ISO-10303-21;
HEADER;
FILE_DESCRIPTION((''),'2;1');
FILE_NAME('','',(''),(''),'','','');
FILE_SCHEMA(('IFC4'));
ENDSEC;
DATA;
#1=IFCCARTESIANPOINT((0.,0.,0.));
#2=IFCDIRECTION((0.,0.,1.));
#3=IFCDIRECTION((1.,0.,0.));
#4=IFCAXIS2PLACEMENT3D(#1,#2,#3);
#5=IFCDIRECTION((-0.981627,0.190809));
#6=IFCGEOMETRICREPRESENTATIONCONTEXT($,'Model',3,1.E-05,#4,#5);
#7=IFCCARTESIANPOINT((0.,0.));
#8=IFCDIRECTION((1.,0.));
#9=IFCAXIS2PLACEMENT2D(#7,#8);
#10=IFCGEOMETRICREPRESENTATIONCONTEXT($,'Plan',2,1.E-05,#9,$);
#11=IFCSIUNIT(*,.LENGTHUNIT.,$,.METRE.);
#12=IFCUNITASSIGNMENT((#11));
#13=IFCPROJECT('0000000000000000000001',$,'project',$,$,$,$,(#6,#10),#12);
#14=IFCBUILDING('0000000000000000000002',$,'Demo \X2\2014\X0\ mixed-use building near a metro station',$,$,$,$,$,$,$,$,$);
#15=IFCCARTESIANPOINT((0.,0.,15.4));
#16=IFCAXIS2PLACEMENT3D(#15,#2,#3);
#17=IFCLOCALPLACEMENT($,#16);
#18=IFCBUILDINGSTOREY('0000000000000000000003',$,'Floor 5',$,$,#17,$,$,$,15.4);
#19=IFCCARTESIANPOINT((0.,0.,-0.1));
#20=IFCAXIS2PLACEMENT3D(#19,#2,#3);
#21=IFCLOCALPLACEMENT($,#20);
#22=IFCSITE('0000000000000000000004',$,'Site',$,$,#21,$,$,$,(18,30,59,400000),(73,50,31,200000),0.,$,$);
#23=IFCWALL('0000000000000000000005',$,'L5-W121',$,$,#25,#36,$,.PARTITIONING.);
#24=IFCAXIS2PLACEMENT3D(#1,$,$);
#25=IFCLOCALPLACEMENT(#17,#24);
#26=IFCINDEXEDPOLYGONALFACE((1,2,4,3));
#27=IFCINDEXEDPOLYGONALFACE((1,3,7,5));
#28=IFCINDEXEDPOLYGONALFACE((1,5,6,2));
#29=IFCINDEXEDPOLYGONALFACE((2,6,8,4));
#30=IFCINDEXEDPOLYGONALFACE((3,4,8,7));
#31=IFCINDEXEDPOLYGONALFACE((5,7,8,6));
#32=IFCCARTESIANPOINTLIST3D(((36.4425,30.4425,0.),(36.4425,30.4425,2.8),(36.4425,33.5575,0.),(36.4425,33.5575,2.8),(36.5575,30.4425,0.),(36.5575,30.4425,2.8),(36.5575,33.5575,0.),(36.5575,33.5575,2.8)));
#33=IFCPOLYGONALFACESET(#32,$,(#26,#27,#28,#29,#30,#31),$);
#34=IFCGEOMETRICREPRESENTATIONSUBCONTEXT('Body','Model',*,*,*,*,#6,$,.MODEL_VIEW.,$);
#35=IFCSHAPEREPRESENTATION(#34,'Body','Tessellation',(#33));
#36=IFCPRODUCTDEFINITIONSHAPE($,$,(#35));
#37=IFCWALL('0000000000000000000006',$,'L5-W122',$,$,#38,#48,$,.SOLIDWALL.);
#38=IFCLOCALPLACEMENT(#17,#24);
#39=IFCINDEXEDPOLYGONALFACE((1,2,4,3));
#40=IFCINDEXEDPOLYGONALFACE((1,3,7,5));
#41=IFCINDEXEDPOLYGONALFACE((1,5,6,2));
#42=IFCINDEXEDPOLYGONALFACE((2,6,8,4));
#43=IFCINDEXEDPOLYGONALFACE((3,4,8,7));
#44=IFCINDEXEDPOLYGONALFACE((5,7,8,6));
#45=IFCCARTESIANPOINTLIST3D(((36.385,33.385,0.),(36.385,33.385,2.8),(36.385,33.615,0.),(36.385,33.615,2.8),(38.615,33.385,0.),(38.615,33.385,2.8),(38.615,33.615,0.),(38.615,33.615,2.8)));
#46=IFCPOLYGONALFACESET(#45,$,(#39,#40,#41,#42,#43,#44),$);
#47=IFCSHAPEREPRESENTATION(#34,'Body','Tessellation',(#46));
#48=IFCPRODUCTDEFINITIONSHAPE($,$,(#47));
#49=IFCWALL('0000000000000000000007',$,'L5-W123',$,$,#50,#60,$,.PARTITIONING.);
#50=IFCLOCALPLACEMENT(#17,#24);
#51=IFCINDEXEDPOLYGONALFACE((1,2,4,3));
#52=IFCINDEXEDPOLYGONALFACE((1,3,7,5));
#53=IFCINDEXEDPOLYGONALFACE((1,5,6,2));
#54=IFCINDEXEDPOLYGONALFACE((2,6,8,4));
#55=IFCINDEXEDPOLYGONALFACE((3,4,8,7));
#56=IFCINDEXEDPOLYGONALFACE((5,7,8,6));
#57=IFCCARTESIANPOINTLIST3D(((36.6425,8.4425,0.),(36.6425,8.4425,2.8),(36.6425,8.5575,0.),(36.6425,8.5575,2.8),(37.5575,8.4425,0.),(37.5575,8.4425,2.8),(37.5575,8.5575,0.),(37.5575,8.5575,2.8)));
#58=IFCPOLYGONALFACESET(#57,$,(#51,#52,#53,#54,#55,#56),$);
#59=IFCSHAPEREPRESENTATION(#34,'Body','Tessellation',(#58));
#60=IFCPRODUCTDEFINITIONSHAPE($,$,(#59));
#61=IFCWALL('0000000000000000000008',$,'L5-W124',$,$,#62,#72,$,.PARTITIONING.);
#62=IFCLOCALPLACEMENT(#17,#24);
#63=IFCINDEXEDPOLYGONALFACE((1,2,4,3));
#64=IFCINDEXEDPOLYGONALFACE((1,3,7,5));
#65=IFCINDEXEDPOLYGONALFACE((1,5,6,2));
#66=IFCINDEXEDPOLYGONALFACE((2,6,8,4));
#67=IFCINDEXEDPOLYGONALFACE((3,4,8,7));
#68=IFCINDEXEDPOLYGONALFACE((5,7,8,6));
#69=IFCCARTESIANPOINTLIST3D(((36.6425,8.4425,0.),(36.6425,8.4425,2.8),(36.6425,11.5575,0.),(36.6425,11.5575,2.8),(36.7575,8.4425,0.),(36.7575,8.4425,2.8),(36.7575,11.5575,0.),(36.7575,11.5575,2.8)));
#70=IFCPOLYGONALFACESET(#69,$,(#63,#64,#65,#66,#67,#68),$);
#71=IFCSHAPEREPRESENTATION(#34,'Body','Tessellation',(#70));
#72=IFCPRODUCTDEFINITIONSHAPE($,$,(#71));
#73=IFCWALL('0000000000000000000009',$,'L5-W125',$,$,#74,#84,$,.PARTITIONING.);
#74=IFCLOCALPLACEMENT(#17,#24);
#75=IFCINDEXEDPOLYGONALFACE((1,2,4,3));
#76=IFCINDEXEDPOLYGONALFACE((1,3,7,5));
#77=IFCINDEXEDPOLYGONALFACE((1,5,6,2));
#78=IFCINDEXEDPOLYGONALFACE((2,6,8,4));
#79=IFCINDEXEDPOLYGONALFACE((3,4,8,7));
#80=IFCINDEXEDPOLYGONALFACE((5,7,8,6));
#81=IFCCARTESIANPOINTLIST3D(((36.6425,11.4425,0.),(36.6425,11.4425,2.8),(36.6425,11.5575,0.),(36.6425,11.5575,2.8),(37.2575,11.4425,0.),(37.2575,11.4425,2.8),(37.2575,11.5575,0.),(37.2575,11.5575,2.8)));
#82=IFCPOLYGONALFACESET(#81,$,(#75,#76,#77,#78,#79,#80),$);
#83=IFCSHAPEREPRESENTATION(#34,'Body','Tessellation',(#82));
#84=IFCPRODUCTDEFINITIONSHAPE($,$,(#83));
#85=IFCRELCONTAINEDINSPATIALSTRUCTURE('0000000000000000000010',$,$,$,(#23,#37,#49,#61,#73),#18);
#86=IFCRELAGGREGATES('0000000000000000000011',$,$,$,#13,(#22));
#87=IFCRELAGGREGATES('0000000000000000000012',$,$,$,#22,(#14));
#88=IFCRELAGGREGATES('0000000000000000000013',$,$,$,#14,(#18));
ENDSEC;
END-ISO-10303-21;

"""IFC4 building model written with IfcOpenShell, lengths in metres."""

from ifc_helpers import new_model, si_unit, direction, frame, origin_with_axes, origin_2d_with_axis, place, context, subcontext, project, spatial, line, indexed_curve, outline, extrude, element, save


model = new_model("IFC4")

# Units and contexts
model_context = context("Model", 3, precision=1e-05, world=origin_with_axes(), true_north=direction((-0.981627, 0.190809)))
plan_context = context("Plan", 2, precision=1e-05, world=origin_2d_with_axis())
body_context = subcontext(model_context, "Body", "Model", "MODEL_VIEW")
ifc_project = project(units=[si_unit("LENGTHUNIT", "METRE")], contexts=[model_context, plan_context])

# Site, building, storey
site_placement = place(None, frame((0.0, 0.0, -0.1), z_axis=(0.0, 0.0, 1.0), x_axis=(1.0, 0.0, 0.0)))
site = spatial("IfcSite", under=ifc_project, at=site_placement, Name="Site", RefLatitude=(18, 30, 59, 400000), RefLongitude=(73, 50, 31, 200000), RefElevation=0.0)
building = spatial("IfcBuilding", under=site, Name="Demo — mixed-use building near a metro station")
storey_placement = place(None, frame((0.0, 0.0, 15.4), z_axis=(0.0, 0.0, 1.0), x_axis=(1.0, 0.0, 0.0)))
storey = spatial("IfcBuildingStorey", under=building, at=storey_placement, Name="Floor 5", Elevation=15.4)

# Walls
wall_1_placement = place(storey_placement, frame((0.0, 0.0, -15.4), z_axis=(0.0, 0.0, 1.0), x_axis=(1.0, 0.0, 0.0)))
element("IfcWall", 1, at=wall_1_placement, inside=storey, Name="L5-W121", PredefinedType="PARTITIONING", context=body_context, shape_type="SweptSolid", body=[
    extrude(outline(indexed_curve([(36.5575, 33.5575), (36.5575, 30.4425), (36.4425, 30.4425), (36.4425, 33.5575)], segments=[line(1, 2, 3, 4, 1)])), frame((0.0, 0.0, 15.4), z_axis=(0.0, 0.0, 1.0), x_axis=(1.0, 0.0, 0.0)), (0.0, 0.0, 1.0), 2.8),
])
wall_2_placement = place(storey_placement, frame((0.0, 0.0, -15.4), z_axis=(0.0, 0.0, 1.0), x_axis=(1.0, 0.0, 0.0)))
element("IfcWall", 2, at=wall_2_placement, inside=storey, Name="L5-W122", PredefinedType="SOLIDWALL", context=body_context, shape_type="SweptSolid", body=[
    extrude(outline(indexed_curve([(38.615, 33.385), (36.385, 33.385), (36.385, 33.615), (38.615, 33.615)], segments=[line(1, 2, 3, 4, 1)])), frame((0.0, 0.0, 15.4), z_axis=(0.0, 0.0, 1.0), x_axis=(1.0, 0.0, 0.0)), (0.0, 0.0, 1.0), 2.8),
])
wall_3_placement = place(storey_placement, frame((0.0, 0.0, -15.4), z_axis=(0.0, 0.0, 1.0), x_axis=(1.0, 0.0, 0.0)))
element("IfcWall", 3, at=wall_3_placement, inside=storey, Name="L5-W123", PredefinedType="PARTITIONING", context=body_context, shape_type="SweptSolid", body=[
    extrude(outline(indexed_curve([(37.5575, 8.4425), (36.6425, 8.4425), (36.6425, 8.5575), (37.5575, 8.5575)], segments=[line(1, 2, 3, 4, 1)])), frame((0.0, 0.0, 15.4), z_axis=(0.0, 0.0, 1.0), x_axis=(1.0, 0.0, 0.0)), (0.0, 0.0, 1.0), 2.8),
])
wall_4_placement = place(storey_placement, frame((0.0, 0.0, -15.4), z_axis=(0.0, 0.0, 1.0), x_axis=(1.0, 0.0, 0.0)))
element("IfcWall", 4, at=wall_4_placement, inside=storey, Name="L5-W124", PredefinedType="PARTITIONING", context=body_context, shape_type="SweptSolid", body=[
    extrude(outline(indexed_curve([(36.7575, 11.5575), (36.7575, 8.4425), (36.6425, 8.4425), (36.6425, 11.5575)], segments=[line(1, 2, 3, 4, 1)])), frame((0.0, 0.0, 15.4), z_axis=(0.0, 0.0, 1.0), x_axis=(1.0, 0.0, 0.0)), (0.0, 0.0, 1.0), 2.8),
])
wall_5_placement = place(storey_placement, frame((0.0, 0.0, -15.4), z_axis=(0.0, 0.0, 1.0), x_axis=(1.0, 0.0, 0.0)))
element("IfcWall", 5, at=wall_5_placement, inside=storey, Name="L5-W125", PredefinedType="PARTITIONING", context=body_context, shape_type="SweptSolid", body=[
    extrude(outline(indexed_curve([(36.6425, 11.5575), (37.2575, 11.5575), (37.2575, 11.4425), (36.6425, 11.4425)], segments=[line(1, 2, 3, 4, 1)])), frame((0.0, 0.0, 15.4), z_axis=(0.0, 0.0, 1.0), x_axis=(1.0, 0.0, 0.0)), (0.0, 0.0, 1.0), 2.8),
])

save(model, "model.ifc")
